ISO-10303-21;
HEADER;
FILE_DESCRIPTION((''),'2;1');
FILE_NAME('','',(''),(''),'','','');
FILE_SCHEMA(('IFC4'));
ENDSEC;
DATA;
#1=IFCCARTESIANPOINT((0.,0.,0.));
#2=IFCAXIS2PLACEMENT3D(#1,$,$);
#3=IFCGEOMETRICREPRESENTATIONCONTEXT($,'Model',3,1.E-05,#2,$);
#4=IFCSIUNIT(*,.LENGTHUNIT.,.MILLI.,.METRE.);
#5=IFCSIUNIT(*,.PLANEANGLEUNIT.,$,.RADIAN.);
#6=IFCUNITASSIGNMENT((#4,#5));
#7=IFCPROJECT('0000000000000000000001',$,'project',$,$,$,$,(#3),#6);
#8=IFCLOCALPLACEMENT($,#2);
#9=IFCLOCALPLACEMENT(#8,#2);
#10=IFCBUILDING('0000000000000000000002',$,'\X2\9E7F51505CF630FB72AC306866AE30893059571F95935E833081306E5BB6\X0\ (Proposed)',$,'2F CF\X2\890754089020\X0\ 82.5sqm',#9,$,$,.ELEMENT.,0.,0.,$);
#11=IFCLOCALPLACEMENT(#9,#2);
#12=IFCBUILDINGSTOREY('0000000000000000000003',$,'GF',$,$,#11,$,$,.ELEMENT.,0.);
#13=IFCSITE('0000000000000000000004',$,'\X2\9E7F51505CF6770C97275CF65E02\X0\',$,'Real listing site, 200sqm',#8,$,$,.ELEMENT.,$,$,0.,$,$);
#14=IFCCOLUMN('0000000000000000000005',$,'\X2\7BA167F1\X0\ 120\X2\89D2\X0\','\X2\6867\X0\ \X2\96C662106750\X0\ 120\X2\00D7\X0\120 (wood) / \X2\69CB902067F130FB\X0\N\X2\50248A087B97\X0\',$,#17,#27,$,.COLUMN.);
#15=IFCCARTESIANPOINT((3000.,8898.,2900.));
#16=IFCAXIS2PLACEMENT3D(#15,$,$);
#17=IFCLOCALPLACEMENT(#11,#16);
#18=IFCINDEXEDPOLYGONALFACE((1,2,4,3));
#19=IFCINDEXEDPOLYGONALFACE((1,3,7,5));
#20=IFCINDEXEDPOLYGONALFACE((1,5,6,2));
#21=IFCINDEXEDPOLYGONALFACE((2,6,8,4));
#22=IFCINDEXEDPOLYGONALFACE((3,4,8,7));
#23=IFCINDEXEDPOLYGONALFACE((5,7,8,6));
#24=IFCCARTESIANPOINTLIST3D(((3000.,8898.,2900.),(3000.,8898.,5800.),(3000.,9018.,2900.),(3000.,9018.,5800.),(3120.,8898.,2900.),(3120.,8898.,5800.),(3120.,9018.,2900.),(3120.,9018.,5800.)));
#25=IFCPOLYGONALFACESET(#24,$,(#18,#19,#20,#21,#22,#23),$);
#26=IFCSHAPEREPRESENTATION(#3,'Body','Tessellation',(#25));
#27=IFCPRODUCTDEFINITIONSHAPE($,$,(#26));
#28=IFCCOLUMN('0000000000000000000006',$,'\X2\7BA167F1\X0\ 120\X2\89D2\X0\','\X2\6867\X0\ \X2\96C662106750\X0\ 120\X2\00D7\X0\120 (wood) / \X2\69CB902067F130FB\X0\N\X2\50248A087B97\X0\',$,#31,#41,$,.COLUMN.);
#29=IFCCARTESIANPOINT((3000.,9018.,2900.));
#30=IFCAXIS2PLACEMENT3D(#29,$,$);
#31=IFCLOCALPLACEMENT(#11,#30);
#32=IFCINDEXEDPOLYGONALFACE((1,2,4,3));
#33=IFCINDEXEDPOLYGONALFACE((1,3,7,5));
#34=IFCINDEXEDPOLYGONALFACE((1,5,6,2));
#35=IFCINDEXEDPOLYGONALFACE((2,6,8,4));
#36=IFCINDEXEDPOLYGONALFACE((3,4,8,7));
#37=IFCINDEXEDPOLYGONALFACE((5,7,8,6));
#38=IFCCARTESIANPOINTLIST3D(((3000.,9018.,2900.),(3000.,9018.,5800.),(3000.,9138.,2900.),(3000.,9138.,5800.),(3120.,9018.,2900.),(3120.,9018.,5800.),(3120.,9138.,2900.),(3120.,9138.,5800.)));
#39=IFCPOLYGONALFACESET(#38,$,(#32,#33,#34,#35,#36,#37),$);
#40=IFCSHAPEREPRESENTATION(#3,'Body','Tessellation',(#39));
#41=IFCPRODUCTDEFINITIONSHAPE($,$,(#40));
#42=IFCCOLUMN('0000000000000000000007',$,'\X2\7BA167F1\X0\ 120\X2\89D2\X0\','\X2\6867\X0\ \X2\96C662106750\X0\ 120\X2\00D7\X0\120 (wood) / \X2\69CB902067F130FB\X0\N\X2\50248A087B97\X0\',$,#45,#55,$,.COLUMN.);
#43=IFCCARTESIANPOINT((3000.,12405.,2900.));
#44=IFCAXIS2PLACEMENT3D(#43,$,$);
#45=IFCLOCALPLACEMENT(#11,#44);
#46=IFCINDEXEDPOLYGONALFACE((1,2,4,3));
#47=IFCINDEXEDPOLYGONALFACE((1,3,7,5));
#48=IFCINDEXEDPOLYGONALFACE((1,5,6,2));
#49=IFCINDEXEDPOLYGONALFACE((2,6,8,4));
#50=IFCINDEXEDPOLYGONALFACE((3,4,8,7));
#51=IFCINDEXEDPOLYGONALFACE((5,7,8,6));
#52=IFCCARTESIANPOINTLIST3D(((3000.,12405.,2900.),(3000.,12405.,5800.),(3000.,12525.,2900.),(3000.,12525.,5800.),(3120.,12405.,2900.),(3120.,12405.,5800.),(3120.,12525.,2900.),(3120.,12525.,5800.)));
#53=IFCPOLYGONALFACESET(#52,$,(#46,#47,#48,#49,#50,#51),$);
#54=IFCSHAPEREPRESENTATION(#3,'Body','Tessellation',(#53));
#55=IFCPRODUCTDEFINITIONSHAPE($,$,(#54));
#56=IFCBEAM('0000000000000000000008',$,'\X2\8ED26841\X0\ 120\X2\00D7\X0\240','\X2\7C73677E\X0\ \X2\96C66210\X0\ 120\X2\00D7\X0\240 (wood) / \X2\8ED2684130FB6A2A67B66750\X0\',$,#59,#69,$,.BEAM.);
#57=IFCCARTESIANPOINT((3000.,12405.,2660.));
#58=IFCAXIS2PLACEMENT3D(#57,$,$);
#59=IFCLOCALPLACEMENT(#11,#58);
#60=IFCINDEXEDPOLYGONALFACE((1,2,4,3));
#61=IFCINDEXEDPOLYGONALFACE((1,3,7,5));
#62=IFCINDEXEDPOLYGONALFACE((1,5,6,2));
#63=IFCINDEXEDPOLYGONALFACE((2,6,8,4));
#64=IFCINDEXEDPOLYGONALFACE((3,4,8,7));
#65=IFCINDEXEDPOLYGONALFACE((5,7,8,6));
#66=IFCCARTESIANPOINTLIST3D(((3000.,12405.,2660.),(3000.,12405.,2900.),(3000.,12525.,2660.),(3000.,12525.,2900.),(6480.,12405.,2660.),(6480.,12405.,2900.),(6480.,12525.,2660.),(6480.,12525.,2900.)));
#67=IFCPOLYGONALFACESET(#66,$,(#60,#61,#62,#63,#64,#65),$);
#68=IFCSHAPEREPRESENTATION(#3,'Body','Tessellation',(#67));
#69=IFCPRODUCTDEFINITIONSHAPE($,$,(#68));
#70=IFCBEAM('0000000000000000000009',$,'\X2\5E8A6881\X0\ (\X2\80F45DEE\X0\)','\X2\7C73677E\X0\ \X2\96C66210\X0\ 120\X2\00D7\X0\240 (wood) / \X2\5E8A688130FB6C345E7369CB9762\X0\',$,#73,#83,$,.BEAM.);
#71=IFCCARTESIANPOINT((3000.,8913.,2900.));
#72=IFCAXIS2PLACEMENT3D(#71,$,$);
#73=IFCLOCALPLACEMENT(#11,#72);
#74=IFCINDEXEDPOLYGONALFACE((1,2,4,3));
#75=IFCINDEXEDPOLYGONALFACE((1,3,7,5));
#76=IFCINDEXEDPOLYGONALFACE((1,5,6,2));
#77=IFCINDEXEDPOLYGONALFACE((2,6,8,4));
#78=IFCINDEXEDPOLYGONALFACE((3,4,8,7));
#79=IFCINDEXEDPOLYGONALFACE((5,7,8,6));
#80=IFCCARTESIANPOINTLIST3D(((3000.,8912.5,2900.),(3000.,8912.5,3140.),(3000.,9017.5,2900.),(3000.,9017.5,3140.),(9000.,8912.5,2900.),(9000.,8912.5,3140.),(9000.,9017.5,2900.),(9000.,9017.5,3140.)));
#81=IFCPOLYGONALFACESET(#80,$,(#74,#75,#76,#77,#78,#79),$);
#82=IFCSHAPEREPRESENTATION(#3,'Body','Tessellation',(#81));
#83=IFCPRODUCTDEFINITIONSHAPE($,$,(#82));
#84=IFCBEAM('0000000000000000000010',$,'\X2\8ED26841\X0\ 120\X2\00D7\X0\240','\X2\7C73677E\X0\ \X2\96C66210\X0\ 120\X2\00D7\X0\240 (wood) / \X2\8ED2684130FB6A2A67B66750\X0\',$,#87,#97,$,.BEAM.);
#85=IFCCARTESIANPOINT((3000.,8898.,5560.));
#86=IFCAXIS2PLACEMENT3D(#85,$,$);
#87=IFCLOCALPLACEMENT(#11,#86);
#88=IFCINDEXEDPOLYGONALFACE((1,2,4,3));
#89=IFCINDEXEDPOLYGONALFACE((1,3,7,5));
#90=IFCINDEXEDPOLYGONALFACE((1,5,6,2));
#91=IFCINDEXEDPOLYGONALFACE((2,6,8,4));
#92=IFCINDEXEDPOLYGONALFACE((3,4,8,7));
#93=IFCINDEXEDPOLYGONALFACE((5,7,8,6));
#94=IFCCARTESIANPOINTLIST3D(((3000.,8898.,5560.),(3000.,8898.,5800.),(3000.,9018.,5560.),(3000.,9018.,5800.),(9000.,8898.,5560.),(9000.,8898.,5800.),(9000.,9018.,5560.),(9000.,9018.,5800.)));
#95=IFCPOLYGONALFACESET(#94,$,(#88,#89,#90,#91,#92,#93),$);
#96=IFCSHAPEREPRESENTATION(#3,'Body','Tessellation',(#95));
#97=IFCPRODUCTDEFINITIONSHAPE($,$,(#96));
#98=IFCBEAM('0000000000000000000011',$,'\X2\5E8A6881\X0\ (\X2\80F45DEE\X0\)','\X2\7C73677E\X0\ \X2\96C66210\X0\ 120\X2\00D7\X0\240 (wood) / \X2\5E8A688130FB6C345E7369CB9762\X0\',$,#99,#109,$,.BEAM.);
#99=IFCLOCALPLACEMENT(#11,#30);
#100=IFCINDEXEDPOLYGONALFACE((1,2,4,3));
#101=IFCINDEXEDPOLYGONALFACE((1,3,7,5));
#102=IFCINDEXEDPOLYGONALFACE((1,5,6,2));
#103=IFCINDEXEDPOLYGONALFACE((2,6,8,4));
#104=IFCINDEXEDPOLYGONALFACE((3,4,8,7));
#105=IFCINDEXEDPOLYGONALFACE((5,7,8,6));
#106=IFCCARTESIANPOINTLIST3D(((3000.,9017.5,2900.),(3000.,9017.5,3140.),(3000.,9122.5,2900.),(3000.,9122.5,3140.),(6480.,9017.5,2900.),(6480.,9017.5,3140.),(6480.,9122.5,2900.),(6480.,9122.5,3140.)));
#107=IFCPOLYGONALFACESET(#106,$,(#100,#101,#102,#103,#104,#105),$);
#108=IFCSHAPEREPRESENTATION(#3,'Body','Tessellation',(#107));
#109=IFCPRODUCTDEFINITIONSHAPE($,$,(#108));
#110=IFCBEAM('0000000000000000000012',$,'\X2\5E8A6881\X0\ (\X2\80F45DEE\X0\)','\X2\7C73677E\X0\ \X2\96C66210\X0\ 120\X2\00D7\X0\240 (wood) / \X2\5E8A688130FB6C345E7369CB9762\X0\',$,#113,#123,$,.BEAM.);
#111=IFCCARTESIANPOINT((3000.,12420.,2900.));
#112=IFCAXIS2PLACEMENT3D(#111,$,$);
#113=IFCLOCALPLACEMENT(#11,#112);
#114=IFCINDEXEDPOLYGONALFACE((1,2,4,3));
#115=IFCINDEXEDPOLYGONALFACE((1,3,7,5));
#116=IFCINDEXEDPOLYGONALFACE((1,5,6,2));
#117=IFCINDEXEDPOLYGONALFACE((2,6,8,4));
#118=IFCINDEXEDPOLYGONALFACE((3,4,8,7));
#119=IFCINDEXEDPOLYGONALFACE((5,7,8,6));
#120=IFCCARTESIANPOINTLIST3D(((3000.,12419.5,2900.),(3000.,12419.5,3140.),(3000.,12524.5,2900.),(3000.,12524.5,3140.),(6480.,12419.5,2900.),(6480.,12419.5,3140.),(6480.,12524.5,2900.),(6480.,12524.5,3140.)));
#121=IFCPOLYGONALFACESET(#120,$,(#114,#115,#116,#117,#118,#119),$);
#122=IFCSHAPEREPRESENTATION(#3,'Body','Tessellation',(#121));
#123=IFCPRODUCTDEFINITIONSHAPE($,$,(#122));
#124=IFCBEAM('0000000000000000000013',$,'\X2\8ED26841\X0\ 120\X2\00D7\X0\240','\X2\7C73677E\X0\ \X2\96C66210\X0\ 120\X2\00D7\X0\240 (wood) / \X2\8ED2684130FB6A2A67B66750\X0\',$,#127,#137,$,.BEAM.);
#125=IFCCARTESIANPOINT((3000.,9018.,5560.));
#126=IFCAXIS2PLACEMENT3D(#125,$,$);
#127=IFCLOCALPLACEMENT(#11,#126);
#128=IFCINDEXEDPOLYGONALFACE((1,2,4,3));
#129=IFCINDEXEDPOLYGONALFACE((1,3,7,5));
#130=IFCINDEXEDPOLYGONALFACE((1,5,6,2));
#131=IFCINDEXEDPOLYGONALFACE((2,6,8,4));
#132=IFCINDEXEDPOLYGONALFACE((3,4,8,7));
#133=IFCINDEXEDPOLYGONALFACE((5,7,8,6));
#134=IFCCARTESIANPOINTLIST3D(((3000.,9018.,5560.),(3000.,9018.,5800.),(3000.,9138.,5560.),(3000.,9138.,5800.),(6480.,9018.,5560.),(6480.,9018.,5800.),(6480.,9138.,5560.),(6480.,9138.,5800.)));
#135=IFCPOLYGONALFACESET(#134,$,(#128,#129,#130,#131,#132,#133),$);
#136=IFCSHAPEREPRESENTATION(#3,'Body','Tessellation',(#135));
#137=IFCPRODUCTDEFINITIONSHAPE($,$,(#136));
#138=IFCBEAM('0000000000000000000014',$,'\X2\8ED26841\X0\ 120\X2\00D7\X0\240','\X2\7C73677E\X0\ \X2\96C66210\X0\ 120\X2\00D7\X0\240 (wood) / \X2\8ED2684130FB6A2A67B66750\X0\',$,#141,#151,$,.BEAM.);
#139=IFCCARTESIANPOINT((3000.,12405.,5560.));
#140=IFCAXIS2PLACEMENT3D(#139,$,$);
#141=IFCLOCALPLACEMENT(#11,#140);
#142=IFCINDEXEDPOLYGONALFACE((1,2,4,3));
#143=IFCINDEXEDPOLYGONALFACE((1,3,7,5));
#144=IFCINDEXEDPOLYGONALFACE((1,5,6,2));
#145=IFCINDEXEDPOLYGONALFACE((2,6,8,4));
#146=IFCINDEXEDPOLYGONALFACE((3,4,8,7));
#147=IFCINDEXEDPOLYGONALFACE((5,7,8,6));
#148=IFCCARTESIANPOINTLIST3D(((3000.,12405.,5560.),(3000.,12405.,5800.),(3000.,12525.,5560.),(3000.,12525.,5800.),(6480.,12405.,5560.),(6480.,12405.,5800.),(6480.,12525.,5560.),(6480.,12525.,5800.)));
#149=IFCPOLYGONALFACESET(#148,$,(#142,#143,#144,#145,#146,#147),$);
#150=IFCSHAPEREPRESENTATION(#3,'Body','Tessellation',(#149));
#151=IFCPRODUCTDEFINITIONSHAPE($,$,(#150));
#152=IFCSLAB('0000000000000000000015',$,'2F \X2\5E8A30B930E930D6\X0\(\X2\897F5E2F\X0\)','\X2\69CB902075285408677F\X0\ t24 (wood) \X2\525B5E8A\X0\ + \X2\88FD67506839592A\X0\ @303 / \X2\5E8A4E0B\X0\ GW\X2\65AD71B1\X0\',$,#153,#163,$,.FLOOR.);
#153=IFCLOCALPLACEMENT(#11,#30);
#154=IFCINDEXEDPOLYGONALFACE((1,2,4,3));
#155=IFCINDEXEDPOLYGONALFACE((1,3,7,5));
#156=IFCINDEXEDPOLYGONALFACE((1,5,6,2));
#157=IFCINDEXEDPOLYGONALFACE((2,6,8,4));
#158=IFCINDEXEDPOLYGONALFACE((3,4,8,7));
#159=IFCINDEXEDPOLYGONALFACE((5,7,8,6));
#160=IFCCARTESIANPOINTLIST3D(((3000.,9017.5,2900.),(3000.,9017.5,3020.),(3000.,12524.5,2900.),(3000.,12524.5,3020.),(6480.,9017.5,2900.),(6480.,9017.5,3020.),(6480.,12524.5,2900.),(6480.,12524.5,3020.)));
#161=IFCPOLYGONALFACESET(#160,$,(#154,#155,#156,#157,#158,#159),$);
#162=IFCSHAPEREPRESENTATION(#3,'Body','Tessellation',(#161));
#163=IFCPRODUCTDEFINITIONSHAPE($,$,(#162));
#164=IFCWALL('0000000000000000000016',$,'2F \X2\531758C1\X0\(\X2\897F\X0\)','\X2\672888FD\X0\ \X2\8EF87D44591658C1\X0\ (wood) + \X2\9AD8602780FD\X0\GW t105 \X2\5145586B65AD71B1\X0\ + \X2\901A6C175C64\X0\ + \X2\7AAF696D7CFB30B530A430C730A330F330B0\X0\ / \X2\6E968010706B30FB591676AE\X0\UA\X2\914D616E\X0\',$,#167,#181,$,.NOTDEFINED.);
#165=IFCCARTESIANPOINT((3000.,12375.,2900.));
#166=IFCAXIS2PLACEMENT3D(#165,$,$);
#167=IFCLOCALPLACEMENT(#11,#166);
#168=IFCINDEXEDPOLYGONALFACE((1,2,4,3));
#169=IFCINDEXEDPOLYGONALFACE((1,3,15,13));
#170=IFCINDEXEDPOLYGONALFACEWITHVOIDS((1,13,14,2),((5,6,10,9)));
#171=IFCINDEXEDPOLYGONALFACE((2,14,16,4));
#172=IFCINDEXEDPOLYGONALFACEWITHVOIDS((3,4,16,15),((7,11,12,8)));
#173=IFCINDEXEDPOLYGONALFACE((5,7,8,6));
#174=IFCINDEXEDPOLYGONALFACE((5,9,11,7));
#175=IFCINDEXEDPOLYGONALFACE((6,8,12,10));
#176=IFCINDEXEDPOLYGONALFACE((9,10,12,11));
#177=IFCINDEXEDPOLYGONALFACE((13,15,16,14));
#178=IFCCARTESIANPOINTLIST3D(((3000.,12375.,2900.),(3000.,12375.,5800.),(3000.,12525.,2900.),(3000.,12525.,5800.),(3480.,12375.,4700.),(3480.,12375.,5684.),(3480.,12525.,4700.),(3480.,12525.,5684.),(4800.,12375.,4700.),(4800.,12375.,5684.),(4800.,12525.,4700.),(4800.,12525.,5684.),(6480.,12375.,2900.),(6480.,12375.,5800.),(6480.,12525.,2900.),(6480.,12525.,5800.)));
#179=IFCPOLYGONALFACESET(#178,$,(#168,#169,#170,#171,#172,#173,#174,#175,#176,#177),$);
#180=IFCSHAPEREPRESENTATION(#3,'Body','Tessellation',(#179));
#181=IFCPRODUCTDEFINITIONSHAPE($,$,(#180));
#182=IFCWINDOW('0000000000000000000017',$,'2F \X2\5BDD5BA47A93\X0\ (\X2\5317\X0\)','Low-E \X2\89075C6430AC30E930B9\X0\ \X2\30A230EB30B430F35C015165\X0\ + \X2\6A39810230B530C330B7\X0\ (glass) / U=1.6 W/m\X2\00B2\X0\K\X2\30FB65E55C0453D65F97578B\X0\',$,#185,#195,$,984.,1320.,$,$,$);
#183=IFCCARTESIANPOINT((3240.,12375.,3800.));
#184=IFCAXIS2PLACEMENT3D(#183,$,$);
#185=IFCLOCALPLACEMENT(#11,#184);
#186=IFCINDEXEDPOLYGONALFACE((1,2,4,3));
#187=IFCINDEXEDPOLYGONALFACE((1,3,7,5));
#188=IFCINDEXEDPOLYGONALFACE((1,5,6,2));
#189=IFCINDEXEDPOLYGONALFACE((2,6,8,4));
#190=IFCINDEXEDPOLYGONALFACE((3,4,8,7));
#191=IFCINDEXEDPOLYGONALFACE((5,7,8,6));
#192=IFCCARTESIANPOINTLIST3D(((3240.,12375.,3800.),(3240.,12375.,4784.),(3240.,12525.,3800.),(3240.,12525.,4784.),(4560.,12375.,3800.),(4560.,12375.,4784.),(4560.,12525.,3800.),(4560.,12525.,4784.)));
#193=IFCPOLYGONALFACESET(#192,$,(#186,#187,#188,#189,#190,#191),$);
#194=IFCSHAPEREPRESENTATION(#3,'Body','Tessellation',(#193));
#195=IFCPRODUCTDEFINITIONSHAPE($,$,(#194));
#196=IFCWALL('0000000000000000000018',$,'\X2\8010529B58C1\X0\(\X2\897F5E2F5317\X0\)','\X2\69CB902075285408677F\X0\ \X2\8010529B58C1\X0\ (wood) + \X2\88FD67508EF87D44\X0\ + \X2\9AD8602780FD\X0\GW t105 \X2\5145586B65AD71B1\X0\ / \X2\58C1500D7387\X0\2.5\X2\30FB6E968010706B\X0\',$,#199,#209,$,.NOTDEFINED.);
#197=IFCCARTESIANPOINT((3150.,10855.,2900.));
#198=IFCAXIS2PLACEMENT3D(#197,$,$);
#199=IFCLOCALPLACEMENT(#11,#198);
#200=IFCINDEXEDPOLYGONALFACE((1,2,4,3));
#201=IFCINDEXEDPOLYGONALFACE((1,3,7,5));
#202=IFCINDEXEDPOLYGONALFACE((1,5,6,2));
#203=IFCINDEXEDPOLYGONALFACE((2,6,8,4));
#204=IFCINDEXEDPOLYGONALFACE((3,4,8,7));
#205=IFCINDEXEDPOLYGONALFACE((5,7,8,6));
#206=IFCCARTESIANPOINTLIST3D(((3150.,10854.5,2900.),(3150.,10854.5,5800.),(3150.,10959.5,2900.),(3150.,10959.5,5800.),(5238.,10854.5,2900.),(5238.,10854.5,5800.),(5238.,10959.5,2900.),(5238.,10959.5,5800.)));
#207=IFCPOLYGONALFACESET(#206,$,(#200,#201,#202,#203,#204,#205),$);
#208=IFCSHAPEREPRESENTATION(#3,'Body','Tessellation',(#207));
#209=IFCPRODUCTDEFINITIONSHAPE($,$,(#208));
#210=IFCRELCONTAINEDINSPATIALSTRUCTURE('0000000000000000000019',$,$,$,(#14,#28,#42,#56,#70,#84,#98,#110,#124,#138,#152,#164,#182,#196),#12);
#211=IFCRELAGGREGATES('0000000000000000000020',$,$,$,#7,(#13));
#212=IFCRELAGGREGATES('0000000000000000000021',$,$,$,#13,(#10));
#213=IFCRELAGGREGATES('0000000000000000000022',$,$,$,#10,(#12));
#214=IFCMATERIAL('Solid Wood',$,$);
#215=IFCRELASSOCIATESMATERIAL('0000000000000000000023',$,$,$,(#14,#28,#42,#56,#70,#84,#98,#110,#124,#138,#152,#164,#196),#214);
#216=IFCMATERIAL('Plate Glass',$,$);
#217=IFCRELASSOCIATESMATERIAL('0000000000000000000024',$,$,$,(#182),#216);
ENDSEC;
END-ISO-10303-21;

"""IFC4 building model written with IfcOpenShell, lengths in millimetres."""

from ifc_helpers import new_model, si_unit, frame, frame_2d, origin, place, context, project, spatial, rectangle, extrude, material, element, fill, save


model = new_model("IFC4")

# Units and contexts
model_context = context("Model", 3, precision=1e-05, world=origin())
ifc_project = project(units=[si_unit("LENGTHUNIT", "METRE", prefix="MILLI"), si_unit("PLANEANGLEUNIT", "RADIAN")], contexts=[model_context])

# Site, building, storey
site_placement = place(None, origin())
site = spatial("IfcSite", under=ifc_project, at=site_placement, Name="鹿児島県霧島市", ObjectType="Real listing site, 200sqm", CompositionType="ELEMENT", RefElevation=0.0)
building_placement = place(site_placement, origin())
building = spatial("IfcBuilding", under=site, at=building_placement, Name="鹿児島・犬と暮らす土間広めの家 (Proposed)", ObjectType="2F CF複合造 82.5sqm", CompositionType="ELEMENT", ElevationOfRefHeight=0.0, ElevationOfTerrain=0.0)
storey_placement = place(building_placement, origin())
storey = spatial("IfcBuildingStorey", under=building, at=storey_placement, Name="GF", CompositionType="ELEMENT", Elevation=0.0)

# Columns
ifc_material_1 = material(Name="Solid Wood")
column_1_placement = place(storey_placement, frame((3000.0, 8898.0, 2900.0)))
element("IfcColumn", 1, at=column_1_placement, inside=storey, material=ifc_material_1, Name="管柱 120角", Description="桧 集成材 120×120 (wood) / 構造柱・N値計算", PredefinedType="COLUMN", context=model_context, shape_type="SweptSolid", body=[
    extrude(rectangle(XDim=120.0, YDim=120.0, at=frame_2d((60.0, 60.0))), frame((3000.0, 8898.0, 2900.0)), (0.0, 0.0, 1.0), 2900.0),
])
column_2_placement = place(storey_placement, frame((3000.0, 9018.0, 2900.0)))
element("IfcColumn", 2, at=column_2_placement, inside=storey, material=ifc_material_1, Name="管柱 120角", Description="桧 集成材 120×120 (wood) / 構造柱・N値計算", PredefinedType="COLUMN", context=model_context, shape_type="SweptSolid", body=[
    extrude(rectangle(XDim=120.0, YDim=120.0, at=frame_2d((60.0, 60.0))), frame((3000.0, 9018.0, 2900.0)), (0.0, 0.0, 1.0), 2900.0),
])
column_3_placement = place(storey_placement, frame((3000.0, 12405.0, 2900.0)))
element("IfcColumn", 3, at=column_3_placement, inside=storey, material=ifc_material_1, Name="管柱 120角", Description="桧 集成材 120×120 (wood) / 構造柱・N値計算", PredefinedType="COLUMN", context=model_context, shape_type="SweptSolid", body=[
    extrude(rectangle(XDim=120.0, YDim=120.0, at=frame_2d((60.0, 60.0))), frame((3000.0, 12405.0, 2900.0)), (0.0, 0.0, 1.0), 2900.0),
])

# Beams
beam_1_placement = place(storey_placement, frame((3000.0, 12405.0, 2660.0)))
element("IfcBeam", 4, at=beam_1_placement, inside=storey, material=ifc_material_1, Name="軒桁 120×240", Description="米松 集成 120×240 (wood) / 軒桁・横架材", PredefinedType="BEAM", context=model_context, shape_type="SweptSolid", body=[
    extrude(rectangle(XDim=3480.0, YDim=120.0, at=frame_2d((1740.0, 60.0))), frame((3000.0, 12405.0, 2660.0)), (0.0, 0.0, 1.0), 240.0),
])
beam_2_placement = place(storey_placement, frame((3000.0, 8913.0, 2900.0)))
element("IfcBeam", 5, at=beam_2_placement, inside=storey, material=ifc_material_1, Name="床梁 (胴差)", Description="米松 集成 120×240 (wood) / 床梁・水平構面", PredefinedType="BEAM", context=model_context, shape_type="SweptSolid", body=[
    extrude(rectangle(XDim=6000.0, YDim=105.0, at=frame_2d((3000.0, 52.0))), frame((3000.0, 8913.0, 2900.0)), (0.0, 0.0, 1.0), 240.0),
])
beam_3_placement = place(storey_placement, frame((3000.0, 8898.0, 5560.0)))
element("IfcBeam", 6, at=beam_3_placement, inside=storey, material=ifc_material_1, Name="軒桁 120×240", Description="米松 集成 120×240 (wood) / 軒桁・横架材", PredefinedType="BEAM", context=model_context, shape_type="SweptSolid", body=[
    extrude(rectangle(XDim=6000.0, YDim=120.0, at=frame_2d((3000.0, 60.0))), frame((3000.0, 8898.0, 5560.0)), (0.0, 0.0, 1.0), 240.0),
])
beam_4_placement = place(storey_placement, frame((3000.0, 9018.0, 2900.0)))
element("IfcBeam", 7, at=beam_4_placement, inside=storey, material=ifc_material_1, Name="床梁 (胴差)", Description="米松 集成 120×240 (wood) / 床梁・水平構面", PredefinedType="BEAM", context=model_context, shape_type="SweptSolid", body=[
    extrude(rectangle(XDim=3480.0, YDim=105.0, at=frame_2d((1740.0, 52.0))), frame((3000.0, 9018.0, 2900.0)), (0.0, 0.0, 1.0), 240.0),
])
beam_5_placement = place(storey_placement, frame((3000.0, 12420.0, 2900.0)))
element("IfcBeam", 8, at=beam_5_placement, inside=storey, material=ifc_material_1, Name="床梁 (胴差)", Description="米松 集成 120×240 (wood) / 床梁・水平構面", PredefinedType="BEAM", context=model_context, shape_type="SweptSolid", body=[
    extrude(rectangle(XDim=3480.0, YDim=105.0, at=frame_2d((1740.0, 52.0))), frame((3000.0, 12420.0, 2900.0)), (0.0, 0.0, 1.0), 240.0),
])
beam_6_placement = place(storey_placement, frame((3000.0, 9018.0, 5560.0)))
element("IfcBeam", 9, at=beam_6_placement, inside=storey, material=ifc_material_1, Name="軒桁 120×240", Description="米松 集成 120×240 (wood) / 軒桁・横架材", PredefinedType="BEAM", context=model_context, shape_type="SweptSolid", body=[
    extrude(rectangle(XDim=3480.0, YDim=120.0, at=frame_2d((1740.0, 60.0))), frame((3000.0, 9018.0, 5560.0)), (0.0, 0.0, 1.0), 240.0),
])
beam_7_placement = place(storey_placement, frame((3000.0, 12405.0, 5560.0)))
element("IfcBeam", 10, at=beam_7_placement, inside=storey, material=ifc_material_1, Name="軒桁 120×240", Description="米松 集成 120×240 (wood) / 軒桁・横架材", PredefinedType="BEAM", context=model_context, shape_type="SweptSolid", body=[
    extrude(rectangle(XDim=3480.0, YDim=120.0, at=frame_2d((1740.0, 60.0))), frame((3000.0, 12405.0, 5560.0)), (0.0, 0.0, 1.0), 240.0),
])

# Slab
slab_placement = place(storey_placement, frame((3000.0, 9018.0, 2900.0)))
element("IfcSlab", 11, at=slab_placement, inside=storey, material=ifc_material_1, Name="2F 床スラブ(西帯)", Description="構造用合板 t24 (wood) 剛床 + 製材根太 @303 / 床下 GW断熱", PredefinedType="FLOOR", context=model_context, shape_type="SweptSolid", body=[
    extrude(rectangle(XDim=3480.0, YDim=3507.0, at=frame_2d((1740.0, 1753.0))), frame((3000.0, 9018.0, 2900.0)), (0.0, 0.0, 1.0), 120.0),
])

# Wall, opening, window
wall_1_placement = place(storey_placement, frame((3000.0, 12375.0, 2900.0)))
wall_1 = element("IfcWall", 12, at=wall_1_placement, inside=storey, material=ifc_material_1, Name="2F 北壁(西)", Description="木製 軸組外壁 (wood) + 高性能GW t105 充填断熱 + 通気層 + 窯業系サイディング / 準耐火・外皮UA配慮", PredefinedType="NOTDEFINED", context=model_context, shape_type="SweptSolid", body=[
    extrude(rectangle(XDim=3480.0, YDim=150.0, at=frame_2d((1740.0, 75.0))), frame((3000.0, 12375.0, 2900.0)), (0.0, 0.0, 1.0), 2900.0),
])
opening_placement = place(storey_placement, frame((3240.0, 12375.0, 3800.0)))
opening = element("IfcOpeningElement", 13, at=opening_placement, cuts=wall_1, PredefinedType="NOTDEFINED", context=model_context, shape_type="SweptSolid", body=[
    extrude(rectangle(XDim=1320.0, YDim=150.0, at=frame_2d((660.0, 75.0))), frame((3240.0, 12375.0, 3800.0)), (0.0, 0.0, 1.0), 984.0),
])
ifc_material_2 = material(Name="Plate Glass")
window_placement = place(storey_placement, frame((3240.0, 12375.0, 3800.0)))
window = element("IfcWindow", 14, at=window_placement, inside=storey, material=ifc_material_2, Name="2F 寝室窓 (北)", Description="Low-E 複層ガラス アルゴン封入 + 樹脂サッシ (glass) / U=1.6 W/m²K・日射取得型", OverallHeight=984.0, OverallWidth=1320.0, context=model_context, shape_type="SweptSolid", body=[
    extrude(rectangle(XDim=1320.0, YDim=150.0, at=frame_2d((660.0, 75.0))), frame((3240.0, 12375.0, 3800.0)), (0.0, 0.0, 1.0), 984.0),
])
fill(opening, window)

# Wall
wall_2_placement = place(storey_placement, frame((3150.0, 10855.0, 2900.0)))
element("IfcWall", 15, at=wall_2_placement, inside=storey, material=ifc_material_1, Name="耐力壁(西帯北)", Description="構造用合板 耐力壁 (wood) + 製材軸組 + 高性能GW t105 充填断熱 / 壁倍率2.5・準耐火", PredefinedType="NOTDEFINED", context=model_context, shape_type="SweptSolid", body=[
    extrude(rectangle(XDim=2088.0, YDim=105.0, at=frame_2d((1044.0, 52.0))), frame((3150.0, 10855.0, 2900.0)), (0.0, 0.0, 1.0), 2900.0),
])

save(model, "model.ifc")
